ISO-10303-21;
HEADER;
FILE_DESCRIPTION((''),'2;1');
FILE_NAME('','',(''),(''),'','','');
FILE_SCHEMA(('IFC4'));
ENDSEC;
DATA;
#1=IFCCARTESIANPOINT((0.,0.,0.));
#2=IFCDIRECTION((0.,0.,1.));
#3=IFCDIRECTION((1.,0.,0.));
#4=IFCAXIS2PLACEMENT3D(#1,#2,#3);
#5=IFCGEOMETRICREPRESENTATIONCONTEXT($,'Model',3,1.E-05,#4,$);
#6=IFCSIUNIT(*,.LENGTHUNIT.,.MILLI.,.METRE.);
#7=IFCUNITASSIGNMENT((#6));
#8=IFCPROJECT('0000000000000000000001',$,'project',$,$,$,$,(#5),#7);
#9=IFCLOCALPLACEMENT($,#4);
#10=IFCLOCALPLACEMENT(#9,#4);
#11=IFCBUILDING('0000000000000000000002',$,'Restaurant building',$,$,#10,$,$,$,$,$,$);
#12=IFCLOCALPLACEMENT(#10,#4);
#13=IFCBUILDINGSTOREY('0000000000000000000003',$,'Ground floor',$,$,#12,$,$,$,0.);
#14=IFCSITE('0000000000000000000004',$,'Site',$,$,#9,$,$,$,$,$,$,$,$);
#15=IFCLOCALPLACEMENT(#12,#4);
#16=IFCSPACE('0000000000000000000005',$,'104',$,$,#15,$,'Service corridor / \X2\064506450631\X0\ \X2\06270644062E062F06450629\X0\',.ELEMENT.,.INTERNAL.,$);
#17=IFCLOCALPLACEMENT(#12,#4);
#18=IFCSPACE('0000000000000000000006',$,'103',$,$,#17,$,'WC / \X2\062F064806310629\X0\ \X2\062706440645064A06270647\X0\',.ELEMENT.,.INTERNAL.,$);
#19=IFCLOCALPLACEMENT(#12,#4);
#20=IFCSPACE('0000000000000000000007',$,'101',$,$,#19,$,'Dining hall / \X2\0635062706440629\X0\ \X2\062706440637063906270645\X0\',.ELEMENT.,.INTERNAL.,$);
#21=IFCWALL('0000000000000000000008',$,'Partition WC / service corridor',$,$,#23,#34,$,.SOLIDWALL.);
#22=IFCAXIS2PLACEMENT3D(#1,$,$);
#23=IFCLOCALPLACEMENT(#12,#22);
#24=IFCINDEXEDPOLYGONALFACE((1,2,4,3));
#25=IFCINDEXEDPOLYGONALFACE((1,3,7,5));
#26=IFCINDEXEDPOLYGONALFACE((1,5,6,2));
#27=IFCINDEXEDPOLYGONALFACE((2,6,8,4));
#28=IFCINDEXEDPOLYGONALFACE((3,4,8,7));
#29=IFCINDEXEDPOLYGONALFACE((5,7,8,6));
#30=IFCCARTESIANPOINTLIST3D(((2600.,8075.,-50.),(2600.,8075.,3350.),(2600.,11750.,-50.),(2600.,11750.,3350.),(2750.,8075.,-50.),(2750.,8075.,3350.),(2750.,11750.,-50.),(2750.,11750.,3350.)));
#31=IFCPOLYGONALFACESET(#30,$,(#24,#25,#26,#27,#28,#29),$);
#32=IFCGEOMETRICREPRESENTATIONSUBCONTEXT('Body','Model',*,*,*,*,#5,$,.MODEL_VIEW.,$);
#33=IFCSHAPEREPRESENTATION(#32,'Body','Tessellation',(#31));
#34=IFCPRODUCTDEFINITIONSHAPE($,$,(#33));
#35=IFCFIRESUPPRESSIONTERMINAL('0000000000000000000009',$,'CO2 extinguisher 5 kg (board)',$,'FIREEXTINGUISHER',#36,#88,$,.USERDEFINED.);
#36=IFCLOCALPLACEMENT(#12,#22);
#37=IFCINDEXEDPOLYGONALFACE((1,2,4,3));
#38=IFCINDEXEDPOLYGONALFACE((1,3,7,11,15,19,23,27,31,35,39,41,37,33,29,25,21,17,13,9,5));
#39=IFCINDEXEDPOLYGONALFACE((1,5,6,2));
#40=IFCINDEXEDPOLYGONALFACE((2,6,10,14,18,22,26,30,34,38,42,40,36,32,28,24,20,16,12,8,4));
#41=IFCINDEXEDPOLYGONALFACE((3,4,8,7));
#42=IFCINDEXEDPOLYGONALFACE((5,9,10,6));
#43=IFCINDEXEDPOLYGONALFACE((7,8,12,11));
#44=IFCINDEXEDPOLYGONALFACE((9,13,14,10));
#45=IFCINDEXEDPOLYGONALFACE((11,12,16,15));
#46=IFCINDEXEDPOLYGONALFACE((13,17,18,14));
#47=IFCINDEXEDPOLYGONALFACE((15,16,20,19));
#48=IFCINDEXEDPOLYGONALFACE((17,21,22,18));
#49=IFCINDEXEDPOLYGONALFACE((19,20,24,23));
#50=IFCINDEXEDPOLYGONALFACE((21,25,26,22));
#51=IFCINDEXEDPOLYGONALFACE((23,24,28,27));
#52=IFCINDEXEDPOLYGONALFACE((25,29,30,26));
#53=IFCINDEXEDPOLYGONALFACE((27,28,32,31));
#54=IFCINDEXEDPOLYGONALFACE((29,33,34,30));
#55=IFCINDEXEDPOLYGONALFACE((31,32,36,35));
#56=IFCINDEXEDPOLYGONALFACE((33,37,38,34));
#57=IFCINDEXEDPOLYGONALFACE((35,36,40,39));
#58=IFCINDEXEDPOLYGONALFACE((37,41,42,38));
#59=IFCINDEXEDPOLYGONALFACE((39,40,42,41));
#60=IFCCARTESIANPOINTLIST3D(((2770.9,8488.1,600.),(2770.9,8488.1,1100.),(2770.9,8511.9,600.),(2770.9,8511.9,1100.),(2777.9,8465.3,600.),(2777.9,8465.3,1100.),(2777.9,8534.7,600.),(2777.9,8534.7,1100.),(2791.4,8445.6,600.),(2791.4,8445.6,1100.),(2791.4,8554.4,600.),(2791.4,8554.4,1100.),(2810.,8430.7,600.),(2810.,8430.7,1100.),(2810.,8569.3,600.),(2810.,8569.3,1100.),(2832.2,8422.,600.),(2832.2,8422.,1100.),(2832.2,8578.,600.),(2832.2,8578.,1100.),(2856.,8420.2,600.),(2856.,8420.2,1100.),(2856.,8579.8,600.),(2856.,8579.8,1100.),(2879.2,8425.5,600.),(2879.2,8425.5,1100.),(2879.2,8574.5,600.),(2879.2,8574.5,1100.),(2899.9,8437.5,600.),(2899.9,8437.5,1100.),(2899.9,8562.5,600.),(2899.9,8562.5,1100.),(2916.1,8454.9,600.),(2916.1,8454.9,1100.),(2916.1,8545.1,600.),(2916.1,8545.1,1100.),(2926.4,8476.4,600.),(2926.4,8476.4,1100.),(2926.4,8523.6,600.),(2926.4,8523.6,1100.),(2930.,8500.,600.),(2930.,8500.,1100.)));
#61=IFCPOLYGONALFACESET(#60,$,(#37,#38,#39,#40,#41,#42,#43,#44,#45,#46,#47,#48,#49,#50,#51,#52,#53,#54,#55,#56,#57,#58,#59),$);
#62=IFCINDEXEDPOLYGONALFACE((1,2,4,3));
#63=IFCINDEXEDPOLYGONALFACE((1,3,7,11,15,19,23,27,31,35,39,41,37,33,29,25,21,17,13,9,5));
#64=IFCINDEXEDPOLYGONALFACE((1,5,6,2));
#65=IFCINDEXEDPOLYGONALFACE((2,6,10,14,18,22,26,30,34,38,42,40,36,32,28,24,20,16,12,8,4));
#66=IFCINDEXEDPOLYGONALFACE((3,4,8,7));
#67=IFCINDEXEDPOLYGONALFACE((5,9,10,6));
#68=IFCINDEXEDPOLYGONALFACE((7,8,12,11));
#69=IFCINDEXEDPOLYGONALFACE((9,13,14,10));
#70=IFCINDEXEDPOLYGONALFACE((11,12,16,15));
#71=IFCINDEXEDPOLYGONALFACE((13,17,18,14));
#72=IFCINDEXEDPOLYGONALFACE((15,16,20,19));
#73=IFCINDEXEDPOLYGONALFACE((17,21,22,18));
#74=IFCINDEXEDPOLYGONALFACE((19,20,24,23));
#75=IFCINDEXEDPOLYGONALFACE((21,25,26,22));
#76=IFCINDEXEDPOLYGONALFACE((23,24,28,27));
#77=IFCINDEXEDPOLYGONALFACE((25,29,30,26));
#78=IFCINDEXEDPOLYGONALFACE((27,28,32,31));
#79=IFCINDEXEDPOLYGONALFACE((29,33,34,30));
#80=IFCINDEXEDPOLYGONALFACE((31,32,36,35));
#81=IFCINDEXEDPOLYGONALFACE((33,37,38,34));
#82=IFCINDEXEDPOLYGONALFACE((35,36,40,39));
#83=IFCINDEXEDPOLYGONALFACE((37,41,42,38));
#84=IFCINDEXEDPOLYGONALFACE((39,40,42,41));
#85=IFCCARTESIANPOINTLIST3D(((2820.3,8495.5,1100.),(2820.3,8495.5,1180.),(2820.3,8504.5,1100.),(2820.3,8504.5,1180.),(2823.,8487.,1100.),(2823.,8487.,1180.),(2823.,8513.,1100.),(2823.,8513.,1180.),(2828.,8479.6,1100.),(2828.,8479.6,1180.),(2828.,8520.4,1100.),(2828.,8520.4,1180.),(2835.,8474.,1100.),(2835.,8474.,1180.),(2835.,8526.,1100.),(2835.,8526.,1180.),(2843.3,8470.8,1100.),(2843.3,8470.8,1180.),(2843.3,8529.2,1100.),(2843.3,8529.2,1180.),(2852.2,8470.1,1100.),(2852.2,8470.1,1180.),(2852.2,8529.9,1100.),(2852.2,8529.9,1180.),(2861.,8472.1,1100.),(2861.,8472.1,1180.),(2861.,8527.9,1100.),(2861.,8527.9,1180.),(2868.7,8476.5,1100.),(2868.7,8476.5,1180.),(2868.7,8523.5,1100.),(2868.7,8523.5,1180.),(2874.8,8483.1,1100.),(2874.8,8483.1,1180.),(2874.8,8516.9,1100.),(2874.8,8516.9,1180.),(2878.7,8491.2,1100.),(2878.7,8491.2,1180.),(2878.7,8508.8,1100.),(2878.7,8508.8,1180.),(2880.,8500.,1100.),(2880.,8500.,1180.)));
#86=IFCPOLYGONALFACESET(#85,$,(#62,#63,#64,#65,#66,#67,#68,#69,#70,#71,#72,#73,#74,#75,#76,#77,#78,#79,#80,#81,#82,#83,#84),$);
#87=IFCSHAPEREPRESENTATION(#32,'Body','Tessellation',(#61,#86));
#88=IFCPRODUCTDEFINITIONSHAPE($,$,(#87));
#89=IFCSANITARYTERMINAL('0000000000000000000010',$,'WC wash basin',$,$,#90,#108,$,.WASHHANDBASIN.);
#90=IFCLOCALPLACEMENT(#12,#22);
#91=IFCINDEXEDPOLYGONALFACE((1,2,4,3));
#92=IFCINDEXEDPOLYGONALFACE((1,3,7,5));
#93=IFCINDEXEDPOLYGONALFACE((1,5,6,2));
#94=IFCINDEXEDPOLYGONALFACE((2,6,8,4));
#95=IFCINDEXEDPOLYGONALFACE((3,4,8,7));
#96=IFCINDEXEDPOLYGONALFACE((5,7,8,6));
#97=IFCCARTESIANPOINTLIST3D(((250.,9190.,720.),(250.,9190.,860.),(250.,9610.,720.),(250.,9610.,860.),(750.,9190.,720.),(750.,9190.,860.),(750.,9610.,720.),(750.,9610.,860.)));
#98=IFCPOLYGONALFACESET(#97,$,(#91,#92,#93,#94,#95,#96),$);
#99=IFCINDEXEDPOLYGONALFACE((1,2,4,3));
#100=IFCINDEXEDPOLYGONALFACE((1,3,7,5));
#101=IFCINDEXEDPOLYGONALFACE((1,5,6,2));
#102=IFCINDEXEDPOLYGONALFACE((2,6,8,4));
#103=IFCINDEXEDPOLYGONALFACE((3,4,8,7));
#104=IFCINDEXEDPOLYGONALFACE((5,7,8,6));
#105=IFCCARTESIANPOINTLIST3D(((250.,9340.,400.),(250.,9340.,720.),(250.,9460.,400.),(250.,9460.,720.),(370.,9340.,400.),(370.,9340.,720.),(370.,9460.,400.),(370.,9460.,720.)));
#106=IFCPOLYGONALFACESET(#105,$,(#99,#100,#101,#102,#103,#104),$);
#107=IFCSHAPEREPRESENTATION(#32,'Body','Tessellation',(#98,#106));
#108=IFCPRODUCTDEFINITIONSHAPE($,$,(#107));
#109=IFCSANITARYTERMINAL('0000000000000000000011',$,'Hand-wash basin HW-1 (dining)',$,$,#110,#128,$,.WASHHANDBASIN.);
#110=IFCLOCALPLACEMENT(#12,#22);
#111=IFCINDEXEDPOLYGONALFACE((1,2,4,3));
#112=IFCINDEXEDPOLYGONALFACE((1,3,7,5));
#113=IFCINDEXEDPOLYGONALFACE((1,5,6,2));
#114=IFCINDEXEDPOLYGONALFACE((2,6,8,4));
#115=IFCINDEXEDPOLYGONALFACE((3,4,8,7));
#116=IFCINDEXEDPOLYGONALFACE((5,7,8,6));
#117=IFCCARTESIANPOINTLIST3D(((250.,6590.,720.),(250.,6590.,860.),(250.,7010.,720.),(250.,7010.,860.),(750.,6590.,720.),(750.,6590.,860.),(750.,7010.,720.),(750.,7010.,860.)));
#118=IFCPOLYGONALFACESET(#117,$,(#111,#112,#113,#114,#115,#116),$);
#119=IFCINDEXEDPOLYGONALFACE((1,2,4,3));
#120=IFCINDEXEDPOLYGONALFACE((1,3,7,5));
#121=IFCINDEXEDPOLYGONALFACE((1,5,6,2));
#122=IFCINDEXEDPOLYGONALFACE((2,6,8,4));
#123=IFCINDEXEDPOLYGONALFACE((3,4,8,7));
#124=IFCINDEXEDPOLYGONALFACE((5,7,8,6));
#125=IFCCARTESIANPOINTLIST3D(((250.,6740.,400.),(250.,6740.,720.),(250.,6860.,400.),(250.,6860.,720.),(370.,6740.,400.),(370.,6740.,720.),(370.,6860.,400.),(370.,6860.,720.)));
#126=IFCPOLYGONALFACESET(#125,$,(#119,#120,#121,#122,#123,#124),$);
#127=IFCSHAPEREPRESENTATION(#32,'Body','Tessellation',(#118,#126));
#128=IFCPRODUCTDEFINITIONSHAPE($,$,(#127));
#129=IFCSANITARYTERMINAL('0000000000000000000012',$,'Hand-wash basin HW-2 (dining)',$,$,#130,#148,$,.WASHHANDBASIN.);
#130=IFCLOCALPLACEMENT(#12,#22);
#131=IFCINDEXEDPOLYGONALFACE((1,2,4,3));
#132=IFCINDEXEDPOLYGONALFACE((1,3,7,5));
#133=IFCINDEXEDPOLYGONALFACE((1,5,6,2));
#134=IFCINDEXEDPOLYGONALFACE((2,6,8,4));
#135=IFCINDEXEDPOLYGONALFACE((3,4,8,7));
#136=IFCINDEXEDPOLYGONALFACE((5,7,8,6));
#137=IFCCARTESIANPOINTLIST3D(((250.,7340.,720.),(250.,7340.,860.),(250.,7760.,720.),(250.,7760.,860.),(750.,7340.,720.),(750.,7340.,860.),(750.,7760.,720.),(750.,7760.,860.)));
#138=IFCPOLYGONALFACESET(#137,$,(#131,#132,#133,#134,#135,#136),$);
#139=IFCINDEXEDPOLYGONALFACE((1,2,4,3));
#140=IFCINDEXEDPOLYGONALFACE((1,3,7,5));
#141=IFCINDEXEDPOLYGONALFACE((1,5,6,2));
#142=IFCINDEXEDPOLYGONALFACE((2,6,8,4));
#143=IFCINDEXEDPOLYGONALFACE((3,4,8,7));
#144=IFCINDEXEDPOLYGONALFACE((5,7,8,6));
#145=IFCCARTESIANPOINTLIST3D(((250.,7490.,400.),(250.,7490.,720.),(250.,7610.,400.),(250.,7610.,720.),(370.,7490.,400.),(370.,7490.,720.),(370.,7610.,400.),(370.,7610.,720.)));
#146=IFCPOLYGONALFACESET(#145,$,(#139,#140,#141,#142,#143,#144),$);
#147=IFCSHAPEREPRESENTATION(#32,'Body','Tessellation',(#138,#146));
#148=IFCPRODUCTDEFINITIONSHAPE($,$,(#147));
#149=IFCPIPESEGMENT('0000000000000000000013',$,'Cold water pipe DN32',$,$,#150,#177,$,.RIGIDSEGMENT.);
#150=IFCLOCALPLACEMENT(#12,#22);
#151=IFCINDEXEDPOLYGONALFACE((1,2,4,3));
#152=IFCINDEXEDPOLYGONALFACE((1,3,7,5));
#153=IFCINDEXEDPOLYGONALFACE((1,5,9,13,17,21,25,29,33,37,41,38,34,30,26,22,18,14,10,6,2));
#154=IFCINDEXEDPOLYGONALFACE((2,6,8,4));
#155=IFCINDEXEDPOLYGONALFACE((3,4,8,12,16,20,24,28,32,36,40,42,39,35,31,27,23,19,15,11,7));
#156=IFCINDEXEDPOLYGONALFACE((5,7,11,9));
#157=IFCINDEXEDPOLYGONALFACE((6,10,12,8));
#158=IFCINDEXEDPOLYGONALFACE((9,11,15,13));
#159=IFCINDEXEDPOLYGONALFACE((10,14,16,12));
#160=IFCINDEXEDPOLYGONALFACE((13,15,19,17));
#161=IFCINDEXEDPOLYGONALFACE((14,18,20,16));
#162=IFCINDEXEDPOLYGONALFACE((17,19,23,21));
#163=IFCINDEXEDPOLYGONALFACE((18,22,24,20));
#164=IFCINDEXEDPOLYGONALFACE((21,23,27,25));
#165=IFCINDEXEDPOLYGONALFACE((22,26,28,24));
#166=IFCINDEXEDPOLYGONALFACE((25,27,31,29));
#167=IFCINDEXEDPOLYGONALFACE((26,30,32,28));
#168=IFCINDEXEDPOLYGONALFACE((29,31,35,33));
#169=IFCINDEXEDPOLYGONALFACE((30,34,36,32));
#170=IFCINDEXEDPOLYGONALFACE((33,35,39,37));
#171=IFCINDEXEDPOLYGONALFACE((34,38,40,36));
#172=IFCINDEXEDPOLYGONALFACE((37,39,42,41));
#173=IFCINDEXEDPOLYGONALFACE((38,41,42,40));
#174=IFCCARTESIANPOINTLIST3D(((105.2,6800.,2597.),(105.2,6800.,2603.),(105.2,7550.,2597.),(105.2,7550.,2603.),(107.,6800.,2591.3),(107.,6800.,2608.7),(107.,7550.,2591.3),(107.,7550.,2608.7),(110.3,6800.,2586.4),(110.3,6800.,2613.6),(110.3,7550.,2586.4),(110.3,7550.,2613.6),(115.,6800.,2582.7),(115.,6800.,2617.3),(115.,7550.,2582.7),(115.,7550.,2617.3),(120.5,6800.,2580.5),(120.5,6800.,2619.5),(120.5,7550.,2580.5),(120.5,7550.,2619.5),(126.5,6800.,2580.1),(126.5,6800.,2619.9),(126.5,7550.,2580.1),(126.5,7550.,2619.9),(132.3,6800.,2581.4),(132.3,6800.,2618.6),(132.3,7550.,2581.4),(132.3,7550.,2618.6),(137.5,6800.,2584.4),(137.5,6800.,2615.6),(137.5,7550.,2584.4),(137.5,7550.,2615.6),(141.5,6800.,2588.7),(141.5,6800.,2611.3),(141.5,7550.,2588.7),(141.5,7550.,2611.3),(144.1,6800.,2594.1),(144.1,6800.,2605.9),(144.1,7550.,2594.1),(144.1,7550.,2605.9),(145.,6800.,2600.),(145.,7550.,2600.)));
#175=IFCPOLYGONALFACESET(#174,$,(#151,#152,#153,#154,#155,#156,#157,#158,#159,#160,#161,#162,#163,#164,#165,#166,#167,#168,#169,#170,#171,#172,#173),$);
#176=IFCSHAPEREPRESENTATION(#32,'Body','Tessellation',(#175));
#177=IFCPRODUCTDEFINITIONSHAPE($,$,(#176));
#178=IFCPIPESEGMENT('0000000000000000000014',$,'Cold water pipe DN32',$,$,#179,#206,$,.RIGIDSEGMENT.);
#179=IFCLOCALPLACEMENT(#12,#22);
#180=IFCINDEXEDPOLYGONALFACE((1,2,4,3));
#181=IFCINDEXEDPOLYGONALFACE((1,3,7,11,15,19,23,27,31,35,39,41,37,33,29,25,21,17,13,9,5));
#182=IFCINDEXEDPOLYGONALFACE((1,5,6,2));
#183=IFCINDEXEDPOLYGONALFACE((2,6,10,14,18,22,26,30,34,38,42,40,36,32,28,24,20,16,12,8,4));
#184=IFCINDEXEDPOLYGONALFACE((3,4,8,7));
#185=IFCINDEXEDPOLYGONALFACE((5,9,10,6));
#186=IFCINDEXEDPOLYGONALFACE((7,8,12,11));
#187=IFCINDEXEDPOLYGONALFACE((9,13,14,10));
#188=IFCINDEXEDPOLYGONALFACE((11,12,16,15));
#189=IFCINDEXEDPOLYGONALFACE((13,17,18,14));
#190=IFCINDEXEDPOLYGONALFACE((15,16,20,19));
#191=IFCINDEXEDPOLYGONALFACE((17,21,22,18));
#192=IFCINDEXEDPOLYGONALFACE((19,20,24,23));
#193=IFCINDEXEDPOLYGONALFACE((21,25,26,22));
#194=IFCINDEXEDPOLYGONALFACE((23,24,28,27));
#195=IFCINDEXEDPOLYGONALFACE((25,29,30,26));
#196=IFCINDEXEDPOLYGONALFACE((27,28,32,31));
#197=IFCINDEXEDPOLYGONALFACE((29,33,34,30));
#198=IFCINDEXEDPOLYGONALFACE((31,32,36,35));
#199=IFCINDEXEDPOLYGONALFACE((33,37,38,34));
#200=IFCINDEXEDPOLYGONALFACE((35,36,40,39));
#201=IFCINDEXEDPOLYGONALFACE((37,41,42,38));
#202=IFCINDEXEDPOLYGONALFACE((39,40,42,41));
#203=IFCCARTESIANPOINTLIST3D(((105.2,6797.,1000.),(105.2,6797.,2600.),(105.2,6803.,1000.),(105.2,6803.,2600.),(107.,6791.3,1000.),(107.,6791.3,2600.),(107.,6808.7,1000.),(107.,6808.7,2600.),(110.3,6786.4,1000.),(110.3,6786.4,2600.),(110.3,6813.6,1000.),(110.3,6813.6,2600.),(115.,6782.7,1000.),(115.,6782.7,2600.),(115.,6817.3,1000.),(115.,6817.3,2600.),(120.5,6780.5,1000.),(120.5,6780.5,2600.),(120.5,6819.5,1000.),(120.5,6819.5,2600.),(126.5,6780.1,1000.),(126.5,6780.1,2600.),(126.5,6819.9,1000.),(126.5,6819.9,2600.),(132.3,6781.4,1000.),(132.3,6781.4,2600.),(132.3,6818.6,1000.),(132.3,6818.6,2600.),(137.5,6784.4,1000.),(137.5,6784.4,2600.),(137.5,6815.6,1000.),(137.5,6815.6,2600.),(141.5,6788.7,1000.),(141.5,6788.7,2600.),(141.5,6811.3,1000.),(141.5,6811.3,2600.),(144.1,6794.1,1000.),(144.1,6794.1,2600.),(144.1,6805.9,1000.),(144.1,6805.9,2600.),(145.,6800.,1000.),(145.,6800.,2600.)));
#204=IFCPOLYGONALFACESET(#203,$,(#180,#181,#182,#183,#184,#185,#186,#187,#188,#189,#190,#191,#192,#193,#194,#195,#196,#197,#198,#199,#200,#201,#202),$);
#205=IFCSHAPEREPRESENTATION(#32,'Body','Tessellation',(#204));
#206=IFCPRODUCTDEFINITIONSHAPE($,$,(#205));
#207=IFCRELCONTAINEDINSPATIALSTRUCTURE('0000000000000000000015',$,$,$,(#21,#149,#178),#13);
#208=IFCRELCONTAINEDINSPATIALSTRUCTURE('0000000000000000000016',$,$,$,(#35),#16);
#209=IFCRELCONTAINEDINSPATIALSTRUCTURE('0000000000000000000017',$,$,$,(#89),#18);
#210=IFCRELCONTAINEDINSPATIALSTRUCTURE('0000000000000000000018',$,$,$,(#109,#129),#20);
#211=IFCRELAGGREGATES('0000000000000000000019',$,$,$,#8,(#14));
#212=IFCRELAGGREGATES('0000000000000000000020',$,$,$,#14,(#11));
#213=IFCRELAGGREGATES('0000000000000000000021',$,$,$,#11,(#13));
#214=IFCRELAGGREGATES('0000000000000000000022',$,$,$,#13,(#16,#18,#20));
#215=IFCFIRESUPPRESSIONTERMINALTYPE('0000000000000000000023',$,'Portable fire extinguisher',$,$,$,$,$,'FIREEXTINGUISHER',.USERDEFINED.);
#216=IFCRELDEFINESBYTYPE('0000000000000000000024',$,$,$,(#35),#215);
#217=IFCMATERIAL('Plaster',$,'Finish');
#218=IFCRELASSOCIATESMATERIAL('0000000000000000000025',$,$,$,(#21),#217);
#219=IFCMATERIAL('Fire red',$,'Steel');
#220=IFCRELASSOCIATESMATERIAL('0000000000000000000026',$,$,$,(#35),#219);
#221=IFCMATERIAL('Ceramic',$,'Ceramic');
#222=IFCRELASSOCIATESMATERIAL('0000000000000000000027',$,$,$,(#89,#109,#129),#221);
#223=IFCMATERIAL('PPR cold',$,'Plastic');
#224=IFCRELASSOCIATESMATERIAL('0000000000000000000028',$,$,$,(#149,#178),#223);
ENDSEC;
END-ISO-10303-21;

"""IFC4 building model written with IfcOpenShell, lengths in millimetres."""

from ifc_helpers import new_model, si_unit, frame, origin, origin_with_axes, origin_2d, place, context, subcontext, project, spatial, rectangle, circle, extrude, source, transform, mapped, material, type_object, type_shapes, element, save


model = new_model("IFC4")

# Units and contexts
model_context = context("Model", 3, precision=1e-05, world=origin_with_axes())
body_context = subcontext(model_context, "Body", "Model", "MODEL_VIEW")
ifc_project = project(units=[si_unit("LENGTHUNIT", "METRE", prefix="MILLI")], contexts=[model_context])

# Site, building, storey
site_placement = place(None, origin_with_axes())
site = spatial("IfcSite", under=ifc_project, at=site_placement, Name="Site")
building_placement = place(site_placement, origin_with_axes())
building = spatial("IfcBuilding", under=site, at=building_placement, Name="Restaurant building")
storey_placement = place(building_placement, origin_with_axes())
storey = spatial("IfcBuildingStorey", under=building, at=storey_placement, Name="Ground floor", Elevation=0.0)

# Shared definitions
ifc_material_1 = material(Name="Plaster", Category="Finish")

# Wall
wall_1_placement = place(storey_placement, frame((2675.0, 8075.0, 0.0), z_axis=(0.0, 0.0, 1.0), x_axis=(0.0, 1.0, 0.0)))
element("IfcWall", 1, at=wall_1_placement, inside=storey, material=ifc_material_1, Name="Partition WC / service corridor", PredefinedType="SOLIDWALL", context=body_context, shape_type="SweptSolid", body=[
    extrude(rectangle(XDim=3675.0, YDim=150.0, at=origin_2d()), frame((1837.5, 0.0, -50.0)), (0.0, 0.0, 1.0), 3400.0),
])

# Shared definitions
space_1_placement = place(storey_placement, origin_with_axes())
space_1 = spatial("IfcSpace", under=storey, at=space_1_placement, Name="104", LongName="Service corridor / ممر الخدمة", CompositionType="ELEMENT", PredefinedType="INTERNAL")

# Fire suppression terminal
ifc_material_2 = material(Name="Fire red", Category="Steel")
fire_suppression_terminal_type = type_object("IfcFireSuppressionTerminalType", Name="Portable fire extinguisher", ElementType="FIREEXTINGUISHER", PredefinedType="USERDEFINED")
shared_shape = source(origin(), body_context, "Body", "SweptSolid", [
    extrude(circle(Radius=80.0, at=origin_2d()), origin(), (0.0, 0.0, 1.0), 500.0),
    extrude(circle(Radius=30.0, at=origin_2d()), frame((0.0, 0.0, 500.0)), (0.0, 0.0, 1.0), 80.0),
])
type_shapes(fire_suppression_terminal_type, [shared_shape])
fire_suppression_terminal_placement = place(storey_placement, frame((2850.0, 8500.0, 600.0)))
element("IfcFireSuppressionTerminal", 2, at=fire_suppression_terminal_placement, inside=space_1, type_object=fire_suppression_terminal_type, material=ifc_material_2, Name="CO2 extinguisher 5 kg (board)", ObjectType="FIREEXTINGUISHER", PredefinedType="USERDEFINED", context=body_context, shape_type="MappedRepresentation", body=[
    mapped(shared_shape, transform((0.0, 0.0, 0.0))),
])

# Shared definitions
space_2_placement = place(storey_placement, origin_with_axes())
space_2 = spatial("IfcSpace", under=storey, at=space_2_placement, Name="103", LongName="WC / دورة المياه", CompositionType="ELEMENT", PredefinedType="INTERNAL")

# Sanitary terminal
ifc_material_3 = material(Name="Ceramic", Category="Ceramic")
sanitary_terminal_placement = place(storey_placement, frame((250.0, 9400.0, 0.0)))
element("IfcSanitaryTerminal", 3, at=sanitary_terminal_placement, inside=space_2, material=ifc_material_3, Name="WC wash basin", PredefinedType="WASHHANDBASIN", context=body_context, shape_type="SweptSolid", body=[
    extrude(rectangle(XDim=500.0, YDim=420.0, at=origin_2d()), frame((250.0, 0.0, 720.0)), (0.0, 0.0, 1.0), 140.0),
    extrude(rectangle(XDim=120.0, YDim=120.0, at=origin_2d()), frame((60.0, 0.0, 400.0)), (0.0, 0.0, 1.0), 320.0),
])

# Shared definitions
space_3_placement = place(storey_placement, origin_with_axes())
space_3 = spatial("IfcSpace", under=storey, at=space_3_placement, Name="101", LongName="Dining hall / صالة الطعام", CompositionType="ELEMENT", PredefinedType="INTERNAL")

# Sanitary terminals
for number, where, name in (
    (4, (250.0, 6800.0, 0.0), "Hand-wash basin HW-1 (dining)"),
    (5, (250.0, 7550.0, 0.0), "Hand-wash basin HW-2 (dining)"),
):
    element("IfcSanitaryTerminal", number, at=place(storey_placement, frame(where)), inside=space_3, material=ifc_material_3, Name=name, PredefinedType="WASHHANDBASIN", context=body_context, shape_type="SweptSolid", body=[
        extrude(rectangle(XDim=500.0, YDim=420.0, at=origin_2d()), frame((250.0, 0.0, 720.0)), (0.0, 0.0, 1.0), 140.0),
        extrude(rectangle(XDim=120.0, YDim=120.0, at=origin_2d()), frame((60.0, 0.0, 400.0)), (0.0, 0.0, 1.0), 320.0),
    ])

# Pipe segments
ifc_material_4 = material(Name="PPR cold", Category="Plastic")
pipe_segment_1_placement = place(storey_placement, frame((125.0, 7550.0, 2600.0)))
element("IfcPipeSegment", 6, at=pipe_segment_1_placement, inside=storey, material=ifc_material_4, Name="Cold water pipe DN32", PredefinedType="RIGIDSEGMENT", context=body_context, shape_type="SweptSolid", body=[
    extrude(circle(Radius=20.0, at=origin_2d()), frame((0.0, 0.0, 0.0), z_axis=(0.0, -1.0, 0.0), x_axis=(1.0, 0.0, 0.0)), (0.0, 0.0, 1.0), 750.0),
])
pipe_segment_2_placement = place(storey_placement, frame((125.0, 6800.0, 2600.0)))
element("IfcPipeSegment", 7, at=pipe_segment_2_placement, inside=storey, material=ifc_material_4, Name="Cold water pipe DN32", PredefinedType="RIGIDSEGMENT", context=body_context, shape_type="SweptSolid", body=[
    extrude(circle(Radius=20.0, at=origin_2d()), frame((0.0, 0.0, 0.0), z_axis=(0.0, 0.0, -1.0), x_axis=(1.0, 0.0, 0.0)), (0.0, 0.0, 1.0), 1600.0),
])

save(model, "model.ifc")
